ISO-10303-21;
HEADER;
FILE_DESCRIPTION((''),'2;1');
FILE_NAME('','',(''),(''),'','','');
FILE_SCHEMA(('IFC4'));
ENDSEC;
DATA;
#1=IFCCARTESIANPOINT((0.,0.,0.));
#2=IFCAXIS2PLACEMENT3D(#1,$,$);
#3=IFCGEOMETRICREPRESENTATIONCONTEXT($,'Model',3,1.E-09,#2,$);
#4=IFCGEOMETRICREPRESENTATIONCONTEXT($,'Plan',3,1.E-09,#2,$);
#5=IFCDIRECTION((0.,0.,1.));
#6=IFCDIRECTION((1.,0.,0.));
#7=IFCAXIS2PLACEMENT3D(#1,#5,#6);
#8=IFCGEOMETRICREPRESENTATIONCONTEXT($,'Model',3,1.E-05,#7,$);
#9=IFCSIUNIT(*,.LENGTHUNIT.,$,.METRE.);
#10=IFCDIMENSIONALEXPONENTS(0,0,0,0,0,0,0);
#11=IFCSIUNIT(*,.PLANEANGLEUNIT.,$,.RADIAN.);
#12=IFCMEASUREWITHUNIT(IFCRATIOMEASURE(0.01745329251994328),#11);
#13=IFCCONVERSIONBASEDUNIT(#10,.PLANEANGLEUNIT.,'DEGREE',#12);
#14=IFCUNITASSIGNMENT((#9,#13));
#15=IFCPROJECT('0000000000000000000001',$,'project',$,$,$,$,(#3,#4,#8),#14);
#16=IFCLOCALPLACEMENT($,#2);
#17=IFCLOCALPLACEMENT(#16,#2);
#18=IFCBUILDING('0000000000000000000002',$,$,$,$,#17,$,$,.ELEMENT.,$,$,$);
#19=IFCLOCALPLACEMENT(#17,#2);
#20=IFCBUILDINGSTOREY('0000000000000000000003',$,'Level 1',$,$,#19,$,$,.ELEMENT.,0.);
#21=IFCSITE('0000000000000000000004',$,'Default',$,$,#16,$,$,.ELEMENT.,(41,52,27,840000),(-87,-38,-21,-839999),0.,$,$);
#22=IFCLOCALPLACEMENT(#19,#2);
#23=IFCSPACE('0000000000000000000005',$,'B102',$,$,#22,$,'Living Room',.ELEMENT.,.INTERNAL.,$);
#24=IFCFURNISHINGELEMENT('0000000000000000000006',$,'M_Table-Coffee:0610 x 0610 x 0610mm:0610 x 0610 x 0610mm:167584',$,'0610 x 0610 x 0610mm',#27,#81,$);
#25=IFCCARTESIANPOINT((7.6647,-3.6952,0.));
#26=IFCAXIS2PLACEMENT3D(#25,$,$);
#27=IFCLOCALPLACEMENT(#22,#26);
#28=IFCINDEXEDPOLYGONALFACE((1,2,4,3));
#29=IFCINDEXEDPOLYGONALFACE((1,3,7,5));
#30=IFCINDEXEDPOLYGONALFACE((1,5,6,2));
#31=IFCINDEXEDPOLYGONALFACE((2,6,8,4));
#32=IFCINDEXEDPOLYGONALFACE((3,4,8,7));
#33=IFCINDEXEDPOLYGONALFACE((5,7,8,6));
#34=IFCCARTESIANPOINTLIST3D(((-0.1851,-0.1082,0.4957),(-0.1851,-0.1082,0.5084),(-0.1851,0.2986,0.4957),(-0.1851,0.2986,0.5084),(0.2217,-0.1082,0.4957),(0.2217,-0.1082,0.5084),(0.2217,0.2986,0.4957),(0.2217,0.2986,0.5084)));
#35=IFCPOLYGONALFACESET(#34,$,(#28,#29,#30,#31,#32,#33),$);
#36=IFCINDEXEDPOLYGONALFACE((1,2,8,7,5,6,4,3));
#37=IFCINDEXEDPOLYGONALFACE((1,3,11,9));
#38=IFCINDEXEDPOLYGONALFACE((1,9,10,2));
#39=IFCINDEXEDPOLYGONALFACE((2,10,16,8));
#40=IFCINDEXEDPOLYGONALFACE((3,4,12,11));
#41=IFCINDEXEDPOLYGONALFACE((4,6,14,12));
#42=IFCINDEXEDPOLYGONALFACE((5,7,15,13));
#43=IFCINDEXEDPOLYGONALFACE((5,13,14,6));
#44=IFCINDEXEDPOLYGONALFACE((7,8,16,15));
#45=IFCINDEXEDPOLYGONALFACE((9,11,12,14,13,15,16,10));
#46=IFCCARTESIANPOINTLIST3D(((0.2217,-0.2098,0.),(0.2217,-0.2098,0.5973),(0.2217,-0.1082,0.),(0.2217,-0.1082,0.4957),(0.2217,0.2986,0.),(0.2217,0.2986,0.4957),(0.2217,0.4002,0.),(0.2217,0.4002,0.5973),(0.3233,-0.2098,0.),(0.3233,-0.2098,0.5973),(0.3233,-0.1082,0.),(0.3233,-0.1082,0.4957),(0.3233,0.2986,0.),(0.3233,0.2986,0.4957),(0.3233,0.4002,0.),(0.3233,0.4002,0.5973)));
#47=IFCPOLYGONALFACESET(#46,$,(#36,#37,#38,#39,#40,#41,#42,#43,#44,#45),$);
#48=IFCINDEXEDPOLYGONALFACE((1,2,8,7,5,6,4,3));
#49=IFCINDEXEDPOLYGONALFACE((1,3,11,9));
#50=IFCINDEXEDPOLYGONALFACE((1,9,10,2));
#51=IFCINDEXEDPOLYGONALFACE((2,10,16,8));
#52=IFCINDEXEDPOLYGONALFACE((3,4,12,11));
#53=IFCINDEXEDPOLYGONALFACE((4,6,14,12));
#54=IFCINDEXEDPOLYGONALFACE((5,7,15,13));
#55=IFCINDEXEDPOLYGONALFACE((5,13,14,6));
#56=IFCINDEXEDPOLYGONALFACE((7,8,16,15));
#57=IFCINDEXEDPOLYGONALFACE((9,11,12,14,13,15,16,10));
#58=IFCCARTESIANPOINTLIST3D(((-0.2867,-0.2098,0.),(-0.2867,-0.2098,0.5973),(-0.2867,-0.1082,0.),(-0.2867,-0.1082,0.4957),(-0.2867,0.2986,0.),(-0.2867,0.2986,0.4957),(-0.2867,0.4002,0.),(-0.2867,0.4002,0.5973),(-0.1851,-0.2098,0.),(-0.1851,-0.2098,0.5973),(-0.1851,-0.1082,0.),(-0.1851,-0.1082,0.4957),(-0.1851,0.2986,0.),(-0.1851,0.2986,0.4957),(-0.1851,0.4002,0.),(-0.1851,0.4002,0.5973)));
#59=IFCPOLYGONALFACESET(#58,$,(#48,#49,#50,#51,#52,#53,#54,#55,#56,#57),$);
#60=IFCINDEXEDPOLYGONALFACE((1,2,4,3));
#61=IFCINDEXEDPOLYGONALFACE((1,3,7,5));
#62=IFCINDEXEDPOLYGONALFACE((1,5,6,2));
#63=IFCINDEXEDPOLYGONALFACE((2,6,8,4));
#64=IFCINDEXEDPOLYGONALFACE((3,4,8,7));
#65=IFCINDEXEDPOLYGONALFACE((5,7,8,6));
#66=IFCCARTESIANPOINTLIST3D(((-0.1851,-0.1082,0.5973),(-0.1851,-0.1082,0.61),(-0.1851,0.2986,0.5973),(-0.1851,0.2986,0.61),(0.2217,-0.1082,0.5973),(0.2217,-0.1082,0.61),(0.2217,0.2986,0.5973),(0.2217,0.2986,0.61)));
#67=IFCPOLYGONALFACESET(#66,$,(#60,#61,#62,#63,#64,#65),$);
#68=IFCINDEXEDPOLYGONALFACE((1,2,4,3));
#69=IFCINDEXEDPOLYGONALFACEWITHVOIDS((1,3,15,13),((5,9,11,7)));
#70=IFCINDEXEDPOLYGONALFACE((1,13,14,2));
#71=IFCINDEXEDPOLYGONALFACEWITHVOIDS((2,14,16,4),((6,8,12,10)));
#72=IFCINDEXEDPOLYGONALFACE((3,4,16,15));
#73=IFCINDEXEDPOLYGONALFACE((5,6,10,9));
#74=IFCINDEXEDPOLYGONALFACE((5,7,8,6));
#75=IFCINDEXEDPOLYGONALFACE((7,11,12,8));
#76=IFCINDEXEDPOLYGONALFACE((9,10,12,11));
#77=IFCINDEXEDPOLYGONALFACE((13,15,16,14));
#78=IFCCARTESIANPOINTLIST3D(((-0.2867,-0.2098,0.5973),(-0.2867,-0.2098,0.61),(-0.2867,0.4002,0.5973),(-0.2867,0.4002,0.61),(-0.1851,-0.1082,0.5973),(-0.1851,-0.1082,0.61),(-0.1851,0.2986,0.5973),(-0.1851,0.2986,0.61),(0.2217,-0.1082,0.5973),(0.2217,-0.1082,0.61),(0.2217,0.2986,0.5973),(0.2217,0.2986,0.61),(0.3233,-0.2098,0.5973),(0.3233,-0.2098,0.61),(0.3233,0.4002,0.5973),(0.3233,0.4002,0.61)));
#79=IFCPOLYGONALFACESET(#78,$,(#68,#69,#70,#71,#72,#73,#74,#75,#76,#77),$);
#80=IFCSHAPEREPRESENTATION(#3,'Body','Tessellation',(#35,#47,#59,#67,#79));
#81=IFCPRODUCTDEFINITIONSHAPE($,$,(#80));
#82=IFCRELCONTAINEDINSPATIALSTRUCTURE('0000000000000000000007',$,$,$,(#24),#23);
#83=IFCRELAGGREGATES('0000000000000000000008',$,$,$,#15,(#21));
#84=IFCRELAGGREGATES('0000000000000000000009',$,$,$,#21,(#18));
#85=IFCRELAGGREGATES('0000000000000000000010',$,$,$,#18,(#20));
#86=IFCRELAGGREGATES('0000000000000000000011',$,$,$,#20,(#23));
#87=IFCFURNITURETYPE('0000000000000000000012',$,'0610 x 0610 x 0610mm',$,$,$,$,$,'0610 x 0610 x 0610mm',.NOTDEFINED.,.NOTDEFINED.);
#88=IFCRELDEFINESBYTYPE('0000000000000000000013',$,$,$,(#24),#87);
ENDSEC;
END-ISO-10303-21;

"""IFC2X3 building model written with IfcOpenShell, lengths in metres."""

from ifc_helpers import new_model, entity, si_unit, converted_unit, frame, origin, origin_with_axes, origin_2d_with_axis, place, context, project, spatial, polyline, rectangle, outline, extrude, source, transform, mapped, type_object, type_shapes, element, save


model = new_model("IFC2X3")

# Units and contexts
model_context_1 = context("Model", 3, precision=1e-09, world=origin())
plan_context = context("Plan", 3, precision=1e-09, world=origin())
model_context_2 = context("Model", 3, precision=1e-05, world=origin_with_axes())
ifc_project = project(units=[si_unit("LENGTHUNIT", "METRE"), converted_unit("PLANEANGLEUNIT", "DEGREE", entity("IfcRatioMeasure", 0.01745329251994328), si_unit("PLANEANGLEUNIT", "RADIAN"), dimensions=[0, 0, 0, 0, 0, 0, 0])], contexts=[model_context_1, plan_context, model_context_2])

# Site, building, storey, space
site_placement = place(None, origin())
site = spatial("IfcSite", under=ifc_project, at=site_placement, Name="Default", CompositionType="ELEMENT", RefLatitude=(41, 52, 27, 840000), RefLongitude=(-87, -38, -21, -839999), RefElevation=0.0)
building_placement = place(site_placement, origin())
building = spatial("IfcBuilding", under=site, at=building_placement, CompositionType="ELEMENT")
storey_placement = place(building_placement, origin())
storey = spatial("IfcBuildingStorey", under=building, at=storey_placement, Name="Level 1", CompositionType="ELEMENT", Elevation=0.0)
space_placement = place(storey_placement, origin())
space = spatial("IfcSpace", under=storey, at=space_placement, Name="B102", LongName="Living Room", CompositionType="ELEMENT", InteriorOrExteriorSpace="INTERNAL")

# Furnishing element
furniture_type = type_object("IfcFurnitureType", Name="0610 x 0610 x 0610mm", ElementType="0610 x 0610 x 0610mm", AssemblyPlace="NOTDEFINED")
shared_shape = source(origin(), model_context_1, "Body", "SweptSolid", [
    extrude(rectangle(XDim=0.4068, YDim=0.4068, at=origin_2d_with_axis()), frame((0.0183, 0.0952, 0.4957), z_axis=(0.0, 0.0, 1.0), x_axis=(-1.0, 0.0, 0.0)), (0.0, 0.0, 1.0), 0.0127),
    extrude(outline(polyline([(-0.2732, -0.305), (0.324, -0.305), (0.324, 0.305), (-0.2732, 0.305), (-0.2732, 0.2034), (0.2225, 0.2034), (0.2225, -0.2034), (-0.2732, -0.2034), (-0.2732, -0.305)])), frame((0.2217, 0.0952, 0.2732), z_axis=(1.0, 0.0, 0.0), x_axis=(0.0, 0.0, 1.0)), (0.0, 0.0, 1.0), 0.1016),
    extrude(outline(polyline([(-0.305, -0.3241), (0.305, -0.3241), (0.305, 0.2733), (0.2034, 0.2733), (0.2034, -0.2224), (-0.2034, -0.2224), (-0.2034, 0.2733), (-0.305, 0.2733), (-0.305, -0.3241)])), frame((-0.2867, 0.0952, 0.2733), z_axis=(1.0, 0.0, 0.0), x_axis=(0.0, -1.0, 0.0)), (0.0, 0.0, 1.0), 0.1016),
    extrude(rectangle(XDim=0.4068, YDim=0.4068, at=origin_2d_with_axis()), frame((0.0183, 0.0952, 0.5973), z_axis=(0.0, 0.0, 1.0), x_axis=(-1.0, 0.0, 0.0)), (0.0, 0.0, 1.0), 0.0127),
    extrude(outline(polyline([(-0.305, -0.305), (0.305, -0.305), (0.305, 0.305), (-0.305, 0.305), (-0.305, -0.305)]), holes=[polyline([(-0.2034, -0.2034), (-0.2034, 0.2034), (0.2034, 0.2034), (0.2034, -0.2034), (-0.2034, -0.2034)])]), frame((0.0183, 0.0952, 0.5973), z_axis=(0.0, 0.0, 1.0), x_axis=(-1.0, 0.0, 0.0)), (0.0, 0.0, 1.0), 0.0127),
])
type_shapes(furniture_type, [shared_shape])
furnishing_placement = place(space_placement, frame((7.6647, -3.6952, 0.0)))
element("IfcFurnishingElement", 1, at=furnishing_placement, inside=space, type_object=furniture_type, Name="M_Table-Coffee:0610 x 0610 x 0610mm:0610 x 0610 x 0610mm:167584", ObjectType="0610 x 0610 x 0610mm", context=model_context_1, shape_type="MappedRepresentation", body=[
    mapped(shared_shape, transform((0.0, 0.0, 0.0), scale=1.0)),
])

save(model, "model.ifc")
